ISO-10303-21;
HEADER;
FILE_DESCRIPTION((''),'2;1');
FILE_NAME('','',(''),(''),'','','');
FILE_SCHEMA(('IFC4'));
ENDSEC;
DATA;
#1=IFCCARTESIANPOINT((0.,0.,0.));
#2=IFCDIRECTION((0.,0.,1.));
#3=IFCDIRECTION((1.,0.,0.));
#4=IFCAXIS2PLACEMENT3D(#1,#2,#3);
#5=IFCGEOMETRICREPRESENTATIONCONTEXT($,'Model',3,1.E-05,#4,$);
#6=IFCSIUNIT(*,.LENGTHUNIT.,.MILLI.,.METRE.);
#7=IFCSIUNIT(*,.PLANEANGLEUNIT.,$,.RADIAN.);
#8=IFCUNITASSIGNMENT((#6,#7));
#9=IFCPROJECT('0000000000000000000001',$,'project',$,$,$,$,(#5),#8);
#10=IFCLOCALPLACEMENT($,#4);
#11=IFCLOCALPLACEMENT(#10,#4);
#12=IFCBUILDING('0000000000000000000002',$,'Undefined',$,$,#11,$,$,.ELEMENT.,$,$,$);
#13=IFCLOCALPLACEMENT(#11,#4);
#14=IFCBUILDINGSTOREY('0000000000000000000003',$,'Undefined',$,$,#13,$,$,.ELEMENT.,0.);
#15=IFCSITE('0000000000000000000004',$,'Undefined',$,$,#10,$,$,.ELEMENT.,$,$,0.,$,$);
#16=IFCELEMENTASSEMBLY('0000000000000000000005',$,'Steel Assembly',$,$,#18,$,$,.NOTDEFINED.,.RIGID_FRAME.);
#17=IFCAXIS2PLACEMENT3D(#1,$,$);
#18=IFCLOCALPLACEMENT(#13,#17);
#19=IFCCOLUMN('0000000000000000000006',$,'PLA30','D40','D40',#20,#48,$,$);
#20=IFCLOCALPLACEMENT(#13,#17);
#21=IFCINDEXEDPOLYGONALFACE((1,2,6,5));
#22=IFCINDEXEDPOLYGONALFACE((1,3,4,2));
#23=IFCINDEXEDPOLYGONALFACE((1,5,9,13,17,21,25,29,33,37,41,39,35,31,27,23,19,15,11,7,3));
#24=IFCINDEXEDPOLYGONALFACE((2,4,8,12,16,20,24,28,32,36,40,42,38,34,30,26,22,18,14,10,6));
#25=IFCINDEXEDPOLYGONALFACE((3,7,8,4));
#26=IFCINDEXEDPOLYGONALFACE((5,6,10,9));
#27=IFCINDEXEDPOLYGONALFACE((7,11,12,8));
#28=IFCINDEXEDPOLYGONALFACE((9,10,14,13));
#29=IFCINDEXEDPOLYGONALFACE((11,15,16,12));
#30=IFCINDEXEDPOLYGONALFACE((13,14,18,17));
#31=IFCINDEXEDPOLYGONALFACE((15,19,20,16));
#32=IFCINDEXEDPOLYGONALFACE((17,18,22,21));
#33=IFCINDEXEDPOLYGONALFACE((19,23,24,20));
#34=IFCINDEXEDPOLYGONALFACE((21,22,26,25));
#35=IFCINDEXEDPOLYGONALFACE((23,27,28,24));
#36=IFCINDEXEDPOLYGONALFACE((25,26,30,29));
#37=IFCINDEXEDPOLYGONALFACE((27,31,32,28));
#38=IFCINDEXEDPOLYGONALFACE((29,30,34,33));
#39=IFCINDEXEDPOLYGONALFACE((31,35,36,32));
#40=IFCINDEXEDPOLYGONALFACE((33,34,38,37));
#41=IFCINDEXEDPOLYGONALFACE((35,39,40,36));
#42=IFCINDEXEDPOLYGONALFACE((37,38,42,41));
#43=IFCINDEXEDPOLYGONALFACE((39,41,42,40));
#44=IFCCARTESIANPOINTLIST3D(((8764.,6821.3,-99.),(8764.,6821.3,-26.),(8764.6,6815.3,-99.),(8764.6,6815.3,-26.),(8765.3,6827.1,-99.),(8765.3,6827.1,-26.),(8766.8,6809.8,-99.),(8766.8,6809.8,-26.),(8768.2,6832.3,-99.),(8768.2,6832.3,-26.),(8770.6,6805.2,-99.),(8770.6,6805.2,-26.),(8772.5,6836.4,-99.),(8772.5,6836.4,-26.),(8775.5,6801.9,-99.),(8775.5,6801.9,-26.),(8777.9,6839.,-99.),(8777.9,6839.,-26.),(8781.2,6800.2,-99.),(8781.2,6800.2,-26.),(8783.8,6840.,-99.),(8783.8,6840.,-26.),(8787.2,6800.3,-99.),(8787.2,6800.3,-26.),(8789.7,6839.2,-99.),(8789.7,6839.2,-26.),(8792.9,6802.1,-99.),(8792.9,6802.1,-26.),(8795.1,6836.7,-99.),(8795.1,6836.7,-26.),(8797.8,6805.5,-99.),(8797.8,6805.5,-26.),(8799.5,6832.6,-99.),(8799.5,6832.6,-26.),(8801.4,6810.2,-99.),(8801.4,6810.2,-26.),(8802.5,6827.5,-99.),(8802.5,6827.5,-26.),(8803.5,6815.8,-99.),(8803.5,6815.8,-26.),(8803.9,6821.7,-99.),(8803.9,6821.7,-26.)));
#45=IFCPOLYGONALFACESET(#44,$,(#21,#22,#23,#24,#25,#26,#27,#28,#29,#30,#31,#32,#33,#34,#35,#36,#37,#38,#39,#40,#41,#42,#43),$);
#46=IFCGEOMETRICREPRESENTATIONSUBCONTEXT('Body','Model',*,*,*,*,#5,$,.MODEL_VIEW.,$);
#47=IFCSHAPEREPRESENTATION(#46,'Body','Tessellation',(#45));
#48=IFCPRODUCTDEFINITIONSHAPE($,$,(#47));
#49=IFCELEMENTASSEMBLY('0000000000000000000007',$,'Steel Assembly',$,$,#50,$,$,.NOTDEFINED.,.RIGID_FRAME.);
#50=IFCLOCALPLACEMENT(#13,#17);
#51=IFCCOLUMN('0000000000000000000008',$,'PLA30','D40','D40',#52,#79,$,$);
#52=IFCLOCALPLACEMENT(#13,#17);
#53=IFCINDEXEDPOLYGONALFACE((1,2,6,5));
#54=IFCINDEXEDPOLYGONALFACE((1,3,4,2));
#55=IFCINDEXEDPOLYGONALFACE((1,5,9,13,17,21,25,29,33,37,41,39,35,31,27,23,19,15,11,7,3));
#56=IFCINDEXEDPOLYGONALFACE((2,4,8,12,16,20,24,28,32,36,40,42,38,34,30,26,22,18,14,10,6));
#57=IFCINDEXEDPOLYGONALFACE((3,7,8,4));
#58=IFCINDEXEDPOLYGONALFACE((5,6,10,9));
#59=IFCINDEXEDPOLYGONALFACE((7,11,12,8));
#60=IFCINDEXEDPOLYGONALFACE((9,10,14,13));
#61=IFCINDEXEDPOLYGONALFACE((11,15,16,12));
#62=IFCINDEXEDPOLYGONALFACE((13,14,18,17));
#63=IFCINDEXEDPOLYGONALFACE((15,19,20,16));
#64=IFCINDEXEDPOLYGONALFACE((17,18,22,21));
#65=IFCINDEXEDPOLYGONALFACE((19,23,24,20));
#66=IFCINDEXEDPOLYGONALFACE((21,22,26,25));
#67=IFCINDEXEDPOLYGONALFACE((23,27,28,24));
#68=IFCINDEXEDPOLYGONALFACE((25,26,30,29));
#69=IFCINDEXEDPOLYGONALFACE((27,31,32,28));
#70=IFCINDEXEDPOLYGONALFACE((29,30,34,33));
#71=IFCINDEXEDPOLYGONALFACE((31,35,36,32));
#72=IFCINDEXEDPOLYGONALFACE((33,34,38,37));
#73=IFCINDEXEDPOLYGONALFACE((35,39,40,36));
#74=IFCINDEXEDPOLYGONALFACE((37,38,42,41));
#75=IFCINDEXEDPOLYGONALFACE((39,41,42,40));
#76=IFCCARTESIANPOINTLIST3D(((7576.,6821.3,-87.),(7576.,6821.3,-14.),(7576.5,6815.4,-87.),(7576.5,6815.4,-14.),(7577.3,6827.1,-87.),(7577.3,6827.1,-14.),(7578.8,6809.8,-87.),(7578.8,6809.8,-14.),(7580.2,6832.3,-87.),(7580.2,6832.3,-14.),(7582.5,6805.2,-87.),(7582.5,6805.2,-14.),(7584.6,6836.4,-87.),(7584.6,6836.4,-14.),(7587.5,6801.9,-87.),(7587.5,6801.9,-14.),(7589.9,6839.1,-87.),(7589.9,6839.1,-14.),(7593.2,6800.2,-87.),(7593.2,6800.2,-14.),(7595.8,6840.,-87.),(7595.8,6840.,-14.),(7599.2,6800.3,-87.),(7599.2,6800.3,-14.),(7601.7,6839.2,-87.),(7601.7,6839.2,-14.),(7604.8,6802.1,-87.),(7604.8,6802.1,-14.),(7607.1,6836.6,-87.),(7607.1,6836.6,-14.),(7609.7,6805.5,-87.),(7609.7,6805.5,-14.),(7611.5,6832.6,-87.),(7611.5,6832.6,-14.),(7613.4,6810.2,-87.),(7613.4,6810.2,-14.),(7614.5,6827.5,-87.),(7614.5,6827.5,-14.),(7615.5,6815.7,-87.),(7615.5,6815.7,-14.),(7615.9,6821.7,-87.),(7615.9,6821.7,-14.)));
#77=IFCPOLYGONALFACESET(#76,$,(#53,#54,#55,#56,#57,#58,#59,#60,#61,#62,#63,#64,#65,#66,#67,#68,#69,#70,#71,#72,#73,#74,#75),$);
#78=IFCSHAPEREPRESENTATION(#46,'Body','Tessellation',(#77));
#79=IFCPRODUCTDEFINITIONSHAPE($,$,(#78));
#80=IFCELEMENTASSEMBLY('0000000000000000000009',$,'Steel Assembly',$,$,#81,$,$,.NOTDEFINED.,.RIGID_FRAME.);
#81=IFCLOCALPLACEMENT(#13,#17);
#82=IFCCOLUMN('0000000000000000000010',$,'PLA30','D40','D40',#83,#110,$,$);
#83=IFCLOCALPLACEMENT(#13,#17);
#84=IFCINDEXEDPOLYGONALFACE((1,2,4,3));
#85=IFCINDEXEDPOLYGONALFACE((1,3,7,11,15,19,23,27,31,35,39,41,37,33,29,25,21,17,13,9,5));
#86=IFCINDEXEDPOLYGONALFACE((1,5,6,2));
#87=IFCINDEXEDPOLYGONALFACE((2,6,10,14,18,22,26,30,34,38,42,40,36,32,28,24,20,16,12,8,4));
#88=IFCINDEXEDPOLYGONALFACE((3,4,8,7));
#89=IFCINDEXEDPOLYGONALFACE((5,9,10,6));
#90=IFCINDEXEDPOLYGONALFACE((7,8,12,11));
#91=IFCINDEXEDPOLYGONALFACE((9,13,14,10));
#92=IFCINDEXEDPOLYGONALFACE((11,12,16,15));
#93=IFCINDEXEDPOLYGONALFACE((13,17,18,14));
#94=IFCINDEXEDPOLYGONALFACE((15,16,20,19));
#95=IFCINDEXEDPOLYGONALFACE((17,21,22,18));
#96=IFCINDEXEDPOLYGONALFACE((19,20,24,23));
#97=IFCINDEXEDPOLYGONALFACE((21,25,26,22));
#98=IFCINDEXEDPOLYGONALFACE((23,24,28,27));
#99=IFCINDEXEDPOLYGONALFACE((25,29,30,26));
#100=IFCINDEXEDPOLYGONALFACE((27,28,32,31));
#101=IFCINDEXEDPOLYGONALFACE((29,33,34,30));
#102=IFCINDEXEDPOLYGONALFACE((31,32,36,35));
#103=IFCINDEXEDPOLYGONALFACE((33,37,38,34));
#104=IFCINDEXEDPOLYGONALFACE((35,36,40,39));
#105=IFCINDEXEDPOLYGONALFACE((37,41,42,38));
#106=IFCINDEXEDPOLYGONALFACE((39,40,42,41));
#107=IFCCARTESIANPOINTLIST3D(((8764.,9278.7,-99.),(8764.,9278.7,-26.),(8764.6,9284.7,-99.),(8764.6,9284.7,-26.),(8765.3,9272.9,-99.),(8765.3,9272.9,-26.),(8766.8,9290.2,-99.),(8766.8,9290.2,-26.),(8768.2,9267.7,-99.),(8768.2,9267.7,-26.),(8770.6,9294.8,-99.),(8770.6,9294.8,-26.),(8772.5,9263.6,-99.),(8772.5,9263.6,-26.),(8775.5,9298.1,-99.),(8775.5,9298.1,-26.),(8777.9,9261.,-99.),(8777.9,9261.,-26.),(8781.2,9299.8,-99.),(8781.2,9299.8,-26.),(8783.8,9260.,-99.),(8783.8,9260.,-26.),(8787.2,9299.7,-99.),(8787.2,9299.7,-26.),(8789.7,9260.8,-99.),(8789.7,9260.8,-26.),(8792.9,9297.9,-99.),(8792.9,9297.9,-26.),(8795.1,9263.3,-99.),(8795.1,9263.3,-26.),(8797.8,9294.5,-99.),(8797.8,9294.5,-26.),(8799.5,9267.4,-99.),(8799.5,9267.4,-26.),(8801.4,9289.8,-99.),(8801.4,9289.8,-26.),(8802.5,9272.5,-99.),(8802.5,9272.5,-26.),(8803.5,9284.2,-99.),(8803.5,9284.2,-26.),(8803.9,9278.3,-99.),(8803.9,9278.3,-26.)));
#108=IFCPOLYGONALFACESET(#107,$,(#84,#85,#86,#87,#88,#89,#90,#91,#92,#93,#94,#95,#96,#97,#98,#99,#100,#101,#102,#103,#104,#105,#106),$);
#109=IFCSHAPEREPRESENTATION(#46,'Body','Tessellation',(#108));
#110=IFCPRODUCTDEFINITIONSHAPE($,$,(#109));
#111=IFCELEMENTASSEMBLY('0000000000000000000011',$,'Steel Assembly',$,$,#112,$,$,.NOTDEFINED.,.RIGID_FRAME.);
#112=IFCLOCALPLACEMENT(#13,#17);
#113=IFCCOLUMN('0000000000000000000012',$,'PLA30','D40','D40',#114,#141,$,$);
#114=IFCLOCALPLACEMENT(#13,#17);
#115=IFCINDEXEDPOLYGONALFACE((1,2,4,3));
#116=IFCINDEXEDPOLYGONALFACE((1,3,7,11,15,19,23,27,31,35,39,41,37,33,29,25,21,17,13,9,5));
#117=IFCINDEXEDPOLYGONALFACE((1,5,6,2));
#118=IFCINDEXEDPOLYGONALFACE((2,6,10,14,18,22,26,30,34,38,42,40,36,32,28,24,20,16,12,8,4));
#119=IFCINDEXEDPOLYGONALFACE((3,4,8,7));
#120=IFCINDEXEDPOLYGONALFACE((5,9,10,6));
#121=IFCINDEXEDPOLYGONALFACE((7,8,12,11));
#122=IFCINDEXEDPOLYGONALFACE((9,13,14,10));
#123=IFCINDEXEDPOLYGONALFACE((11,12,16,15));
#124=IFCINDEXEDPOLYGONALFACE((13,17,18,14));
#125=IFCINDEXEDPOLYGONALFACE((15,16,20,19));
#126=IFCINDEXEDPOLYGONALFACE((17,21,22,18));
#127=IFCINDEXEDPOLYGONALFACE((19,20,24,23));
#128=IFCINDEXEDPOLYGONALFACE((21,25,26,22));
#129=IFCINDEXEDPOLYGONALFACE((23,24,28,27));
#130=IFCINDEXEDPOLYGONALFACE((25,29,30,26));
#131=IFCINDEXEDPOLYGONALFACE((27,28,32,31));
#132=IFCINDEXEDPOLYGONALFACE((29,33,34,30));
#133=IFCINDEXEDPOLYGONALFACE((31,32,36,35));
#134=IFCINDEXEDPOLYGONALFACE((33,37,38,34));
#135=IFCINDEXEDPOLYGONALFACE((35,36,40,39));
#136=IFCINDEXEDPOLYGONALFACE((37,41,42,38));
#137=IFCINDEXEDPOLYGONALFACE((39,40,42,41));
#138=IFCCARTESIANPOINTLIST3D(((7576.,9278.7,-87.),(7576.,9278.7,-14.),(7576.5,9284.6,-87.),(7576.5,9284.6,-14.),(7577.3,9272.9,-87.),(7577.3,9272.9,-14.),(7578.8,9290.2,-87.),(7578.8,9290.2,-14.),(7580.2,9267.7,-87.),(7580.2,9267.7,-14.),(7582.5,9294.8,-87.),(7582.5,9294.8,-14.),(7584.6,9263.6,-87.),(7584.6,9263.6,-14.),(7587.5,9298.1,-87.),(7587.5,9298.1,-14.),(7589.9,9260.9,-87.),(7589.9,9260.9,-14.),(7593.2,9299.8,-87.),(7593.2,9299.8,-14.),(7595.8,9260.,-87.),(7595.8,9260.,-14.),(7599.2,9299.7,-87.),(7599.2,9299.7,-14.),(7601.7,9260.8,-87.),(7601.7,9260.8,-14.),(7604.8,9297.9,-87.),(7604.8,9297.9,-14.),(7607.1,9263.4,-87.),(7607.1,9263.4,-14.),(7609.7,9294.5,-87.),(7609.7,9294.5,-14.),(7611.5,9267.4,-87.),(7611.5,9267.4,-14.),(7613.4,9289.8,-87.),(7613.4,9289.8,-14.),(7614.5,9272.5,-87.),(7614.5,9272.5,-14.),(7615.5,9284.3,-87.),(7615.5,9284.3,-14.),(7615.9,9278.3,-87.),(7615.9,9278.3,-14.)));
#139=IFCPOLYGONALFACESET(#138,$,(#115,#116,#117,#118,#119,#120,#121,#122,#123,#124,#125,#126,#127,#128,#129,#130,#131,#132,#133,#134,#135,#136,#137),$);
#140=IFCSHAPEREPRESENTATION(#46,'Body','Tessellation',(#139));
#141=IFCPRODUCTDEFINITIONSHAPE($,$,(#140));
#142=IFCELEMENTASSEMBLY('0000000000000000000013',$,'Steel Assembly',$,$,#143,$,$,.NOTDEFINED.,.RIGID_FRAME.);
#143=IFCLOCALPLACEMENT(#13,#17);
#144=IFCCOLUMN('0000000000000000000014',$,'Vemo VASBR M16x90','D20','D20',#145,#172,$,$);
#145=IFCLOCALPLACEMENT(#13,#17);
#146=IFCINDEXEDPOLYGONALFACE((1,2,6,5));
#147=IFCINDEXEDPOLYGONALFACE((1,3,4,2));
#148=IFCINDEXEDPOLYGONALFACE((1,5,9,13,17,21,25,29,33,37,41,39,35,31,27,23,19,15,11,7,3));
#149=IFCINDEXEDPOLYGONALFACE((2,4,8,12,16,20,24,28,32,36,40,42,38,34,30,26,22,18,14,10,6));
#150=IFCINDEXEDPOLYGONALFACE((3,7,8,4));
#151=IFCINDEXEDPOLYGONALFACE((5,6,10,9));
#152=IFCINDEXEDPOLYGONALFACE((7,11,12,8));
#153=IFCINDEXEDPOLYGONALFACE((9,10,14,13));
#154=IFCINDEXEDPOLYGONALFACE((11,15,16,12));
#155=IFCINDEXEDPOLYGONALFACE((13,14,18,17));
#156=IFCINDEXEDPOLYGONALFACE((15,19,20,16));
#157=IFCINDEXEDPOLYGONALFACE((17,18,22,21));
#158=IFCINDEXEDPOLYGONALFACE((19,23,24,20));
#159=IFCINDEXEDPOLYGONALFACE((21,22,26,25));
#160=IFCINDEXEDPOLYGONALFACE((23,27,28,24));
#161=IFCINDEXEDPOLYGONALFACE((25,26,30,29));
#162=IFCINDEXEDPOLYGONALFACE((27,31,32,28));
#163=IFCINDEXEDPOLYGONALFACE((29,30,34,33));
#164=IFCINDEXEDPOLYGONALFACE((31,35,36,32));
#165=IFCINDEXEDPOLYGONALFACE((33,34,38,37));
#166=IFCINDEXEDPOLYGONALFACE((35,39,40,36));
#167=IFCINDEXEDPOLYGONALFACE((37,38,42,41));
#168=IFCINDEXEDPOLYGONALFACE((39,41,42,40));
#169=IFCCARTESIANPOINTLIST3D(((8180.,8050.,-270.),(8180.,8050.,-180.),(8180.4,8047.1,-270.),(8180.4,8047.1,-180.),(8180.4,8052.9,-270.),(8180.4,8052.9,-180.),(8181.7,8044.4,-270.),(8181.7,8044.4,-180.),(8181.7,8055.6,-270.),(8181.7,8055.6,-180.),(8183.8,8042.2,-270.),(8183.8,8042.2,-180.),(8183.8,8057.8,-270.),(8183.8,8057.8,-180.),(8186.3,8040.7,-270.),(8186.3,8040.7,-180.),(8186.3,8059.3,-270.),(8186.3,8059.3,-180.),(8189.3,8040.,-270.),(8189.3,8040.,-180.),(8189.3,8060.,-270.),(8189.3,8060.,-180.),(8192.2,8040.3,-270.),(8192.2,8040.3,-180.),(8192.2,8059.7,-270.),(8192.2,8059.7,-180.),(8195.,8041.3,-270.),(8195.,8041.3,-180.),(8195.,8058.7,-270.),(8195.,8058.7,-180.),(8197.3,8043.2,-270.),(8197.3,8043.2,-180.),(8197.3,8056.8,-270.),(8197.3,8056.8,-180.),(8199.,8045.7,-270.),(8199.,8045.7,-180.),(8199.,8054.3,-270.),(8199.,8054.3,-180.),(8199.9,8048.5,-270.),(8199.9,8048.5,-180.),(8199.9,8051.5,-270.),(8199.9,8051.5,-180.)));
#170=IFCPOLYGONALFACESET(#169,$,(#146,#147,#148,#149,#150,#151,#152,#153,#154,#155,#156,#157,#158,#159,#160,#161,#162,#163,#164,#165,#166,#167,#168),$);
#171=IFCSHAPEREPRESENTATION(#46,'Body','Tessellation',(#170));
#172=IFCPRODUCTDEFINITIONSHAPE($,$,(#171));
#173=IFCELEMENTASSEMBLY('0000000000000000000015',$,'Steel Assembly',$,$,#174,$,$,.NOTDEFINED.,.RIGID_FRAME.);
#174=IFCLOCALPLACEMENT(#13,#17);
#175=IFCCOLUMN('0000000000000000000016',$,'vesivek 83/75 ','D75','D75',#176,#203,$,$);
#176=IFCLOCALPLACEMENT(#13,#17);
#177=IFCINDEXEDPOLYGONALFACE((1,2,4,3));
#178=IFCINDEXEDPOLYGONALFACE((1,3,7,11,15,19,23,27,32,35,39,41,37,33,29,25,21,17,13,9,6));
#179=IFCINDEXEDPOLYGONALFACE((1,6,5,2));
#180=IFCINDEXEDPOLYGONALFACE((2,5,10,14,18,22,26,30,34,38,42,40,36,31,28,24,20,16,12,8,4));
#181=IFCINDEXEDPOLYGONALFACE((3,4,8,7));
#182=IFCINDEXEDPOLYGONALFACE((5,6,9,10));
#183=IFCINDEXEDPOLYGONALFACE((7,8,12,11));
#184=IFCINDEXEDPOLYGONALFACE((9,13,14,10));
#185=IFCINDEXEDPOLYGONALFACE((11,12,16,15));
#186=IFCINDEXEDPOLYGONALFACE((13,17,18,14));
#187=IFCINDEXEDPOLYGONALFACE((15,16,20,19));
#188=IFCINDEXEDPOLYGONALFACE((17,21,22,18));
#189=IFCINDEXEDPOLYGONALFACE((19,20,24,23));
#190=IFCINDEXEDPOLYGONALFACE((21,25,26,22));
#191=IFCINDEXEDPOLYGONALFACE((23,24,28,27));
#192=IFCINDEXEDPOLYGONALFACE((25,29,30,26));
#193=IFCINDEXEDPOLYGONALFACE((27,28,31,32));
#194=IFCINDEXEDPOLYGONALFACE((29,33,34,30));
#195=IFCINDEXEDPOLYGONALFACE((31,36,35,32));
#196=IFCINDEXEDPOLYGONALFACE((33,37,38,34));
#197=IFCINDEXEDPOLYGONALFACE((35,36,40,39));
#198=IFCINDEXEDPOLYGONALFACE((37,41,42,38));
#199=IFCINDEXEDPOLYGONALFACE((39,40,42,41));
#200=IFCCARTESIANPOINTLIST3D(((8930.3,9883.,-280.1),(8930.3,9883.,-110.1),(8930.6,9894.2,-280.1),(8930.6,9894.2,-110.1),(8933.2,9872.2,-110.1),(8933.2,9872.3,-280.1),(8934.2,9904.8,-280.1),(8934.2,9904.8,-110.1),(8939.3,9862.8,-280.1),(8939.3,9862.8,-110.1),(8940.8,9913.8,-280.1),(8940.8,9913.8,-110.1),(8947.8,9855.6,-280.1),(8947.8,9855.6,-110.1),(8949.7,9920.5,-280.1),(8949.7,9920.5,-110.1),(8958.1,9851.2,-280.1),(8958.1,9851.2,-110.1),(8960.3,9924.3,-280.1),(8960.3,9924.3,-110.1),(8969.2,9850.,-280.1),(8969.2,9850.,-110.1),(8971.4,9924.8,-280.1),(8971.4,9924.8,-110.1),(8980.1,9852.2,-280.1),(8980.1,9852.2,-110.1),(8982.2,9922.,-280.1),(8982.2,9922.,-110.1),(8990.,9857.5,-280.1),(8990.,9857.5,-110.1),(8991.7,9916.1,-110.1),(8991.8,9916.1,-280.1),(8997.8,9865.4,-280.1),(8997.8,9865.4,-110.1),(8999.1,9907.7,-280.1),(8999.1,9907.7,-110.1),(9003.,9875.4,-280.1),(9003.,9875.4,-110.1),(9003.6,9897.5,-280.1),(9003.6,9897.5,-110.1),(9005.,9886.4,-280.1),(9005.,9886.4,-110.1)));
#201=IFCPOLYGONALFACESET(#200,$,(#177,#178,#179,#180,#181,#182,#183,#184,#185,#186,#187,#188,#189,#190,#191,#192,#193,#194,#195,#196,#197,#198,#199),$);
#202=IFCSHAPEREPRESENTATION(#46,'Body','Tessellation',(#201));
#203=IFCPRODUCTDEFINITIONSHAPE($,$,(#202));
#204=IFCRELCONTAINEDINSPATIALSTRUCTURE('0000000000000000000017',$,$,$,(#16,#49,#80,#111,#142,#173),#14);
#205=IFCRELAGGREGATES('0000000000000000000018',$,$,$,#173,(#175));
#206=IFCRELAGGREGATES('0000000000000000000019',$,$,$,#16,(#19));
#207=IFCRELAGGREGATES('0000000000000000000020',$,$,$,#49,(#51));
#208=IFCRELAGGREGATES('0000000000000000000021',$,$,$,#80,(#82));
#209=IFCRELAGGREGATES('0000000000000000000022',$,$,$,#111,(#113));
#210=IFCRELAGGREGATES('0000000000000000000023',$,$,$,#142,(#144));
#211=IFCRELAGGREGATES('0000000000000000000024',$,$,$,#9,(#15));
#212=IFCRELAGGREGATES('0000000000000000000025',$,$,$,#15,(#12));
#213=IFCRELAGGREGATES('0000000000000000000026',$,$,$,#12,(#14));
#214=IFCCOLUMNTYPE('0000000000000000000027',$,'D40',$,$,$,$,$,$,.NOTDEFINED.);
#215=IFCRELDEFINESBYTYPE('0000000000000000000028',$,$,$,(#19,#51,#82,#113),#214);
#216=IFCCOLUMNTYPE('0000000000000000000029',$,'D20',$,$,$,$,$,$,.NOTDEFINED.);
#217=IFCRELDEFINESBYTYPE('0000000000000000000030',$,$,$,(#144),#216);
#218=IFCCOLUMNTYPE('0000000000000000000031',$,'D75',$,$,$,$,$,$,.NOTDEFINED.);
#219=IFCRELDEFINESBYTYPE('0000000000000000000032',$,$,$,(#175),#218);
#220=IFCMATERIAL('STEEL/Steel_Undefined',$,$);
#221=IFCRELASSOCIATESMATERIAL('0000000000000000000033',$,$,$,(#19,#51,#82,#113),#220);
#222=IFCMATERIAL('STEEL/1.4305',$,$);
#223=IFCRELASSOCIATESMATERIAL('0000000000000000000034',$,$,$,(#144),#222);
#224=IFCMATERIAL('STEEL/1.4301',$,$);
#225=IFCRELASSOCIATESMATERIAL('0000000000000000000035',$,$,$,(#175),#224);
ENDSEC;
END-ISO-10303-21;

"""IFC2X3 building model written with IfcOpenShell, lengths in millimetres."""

from ifc_helpers import new_model, si_unit, frame, origin_with_axes, origin_2d_with_axis, place, context, subcontext, project, spatial, circle, extrude, material, type_object, element, aggregate, save


model = new_model("IFC2X3")

# Units and contexts
model_context = context("Model", 3, precision=1e-05, world=origin_with_axes())
body_context = subcontext(model_context, "Body", "Model", "MODEL_VIEW")
ifc_project = project(units=[si_unit("LENGTHUNIT", "METRE", prefix="MILLI"), si_unit("PLANEANGLEUNIT", "RADIAN")], contexts=[model_context])

# Site, building, storey
site_placement = place(None, origin_with_axes())
site = spatial("IfcSite", under=ifc_project, at=site_placement, Name="Undefined", CompositionType="ELEMENT", RefElevation=0.0)
building_placement = place(site_placement, origin_with_axes())
building = spatial("IfcBuilding", under=site, at=building_placement, Name="Undefined", CompositionType="ELEMENT")
storey_placement = place(building_placement, origin_with_axes())
storey = spatial("IfcBuildingStorey", under=building, at=storey_placement, Name="Undefined", CompositionType="ELEMENT", Elevation=0.0)

# Element assemblies, columns
assembly_1_placement = place(storey_placement, origin_with_axes())
assembly_1 = element("IfcElementAssembly", 1, at=assembly_1_placement, inside=storey, Name="Steel Assembly", AssemblyPlace="NOTDEFINED", PredefinedType="RIGID_FRAME")
ifc_material_1 = material(Name="STEEL/Steel_Undefined")
column_type_1 = type_object("IfcColumnType", Name="D40", PredefinedType="NOTDEFINED")
column_1_placement = place(assembly_1_placement, frame((8784.0, 6820.0, -99.0), z_axis=(0.0, 0.0, 1.0), x_axis=(-0.895963, -0.444129, 0.0)))
column_1 = element("IfcColumn", 2, at=column_1_placement, type_object=column_type_1, material=ifc_material_1, Name="PLA30", Description="D40", ObjectType="D40", context=body_context, shape_type="SweptSolid", body=[
    extrude(circle(Radius=20.0, at=origin_2d_with_axis()), frame((0.0, 0.0, 73.0), z_axis=(0.0, 0.0, -1.0), x_axis=(0.0, 1.0, 0.0)), (0.0, 0.0, 1.0), 73.0),
])
assembly_2_placement = place(storey_placement, origin_with_axes())
assembly_2 = element("IfcElementAssembly", 3, at=assembly_2_placement, inside=storey, Name="Steel Assembly", AssemblyPlace="NOTDEFINED", PredefinedType="RIGID_FRAME")
column_2_placement = place(assembly_2_placement, frame((7596.0, 6820.0, -87.0), z_axis=(0.0, 0.0, 1.0), x_axis=(-0.904918, 0.425586, 0.0)))
column_2 = element("IfcColumn", 4, at=column_2_placement, type_object=column_type_1, material=ifc_material_1, Name="PLA30", Description="D40", ObjectType="D40", context=body_context, shape_type="SweptSolid", body=[
    extrude(circle(Radius=20.0, at=origin_2d_with_axis()), frame((0.0, 0.0, 73.0), z_axis=(0.0, 0.0, -1.0), x_axis=(0.0, 1.0, 0.0)), (0.0, 0.0, 1.0), 73.0),
])
assembly_3_placement = place(storey_placement, origin_with_axes())
assembly_3 = element("IfcElementAssembly", 5, at=assembly_3_placement, inside=storey, Name="Steel Assembly", AssemblyPlace="NOTDEFINED", PredefinedType="RIGID_FRAME")
column_3_placement = place(assembly_3_placement, frame((8784.0, 9280.0, -99.0), z_axis=(0.0, 0.0, 1.0), x_axis=(0.896018, -0.444018, 0.0)))
column_3 = element("IfcColumn", 6, at=column_3_placement, type_object=column_type_1, material=ifc_material_1, Name="PLA30", Description="D40", ObjectType="D40", context=body_context, shape_type="SweptSolid", body=[
    extrude(circle(Radius=20.0, at=origin_2d_with_axis()), frame((0.0, 0.0, 73.0), z_axis=(0.0, 0.0, -1.0), x_axis=(0.0, 1.0, 0.0)), (0.0, 0.0, 1.0), 73.0),
])
assembly_4_placement = place(storey_placement, origin_with_axes())
assembly_4 = element("IfcElementAssembly", 7, at=assembly_4_placement, inside=storey, Name="Steel Assembly", AssemblyPlace="NOTDEFINED", PredefinedType="RIGID_FRAME")
column_4_placement = place(assembly_4_placement, frame((7596.0, 9280.0, -87.0), z_axis=(0.0, 0.0, 1.0), x_axis=(0.904969, 0.425477, 0.0)))
column_4 = element("IfcColumn", 8, at=column_4_placement, type_object=column_type_1, material=ifc_material_1, Name="PLA30", Description="D40", ObjectType="D40", context=body_context, shape_type="SweptSolid", body=[
    extrude(circle(Radius=20.0, at=origin_2d_with_axis()), frame((0.0, 0.0, 73.0), z_axis=(0.0, 0.0, -1.0), x_axis=(0.0, 1.0, 0.0)), (0.0, 0.0, 1.0), 73.0),
])
assembly_5_placement = place(storey_placement, origin_with_axes())
assembly_5 = element("IfcElementAssembly", 9, at=assembly_5_placement, inside=storey, Name="Steel Assembly", AssemblyPlace="NOTDEFINED", PredefinedType="RIGID_FRAME")
ifc_material_2 = material(Name="STEEL/1.4305")
column_type_2 = type_object("IfcColumnType", Name="D20", PredefinedType="NOTDEFINED")
column_5_placement = place(assembly_5_placement, frame((8190.0, 8050.0, -270.0), z_axis=(0.0, 0.0, 1.0), x_axis=(0.0, 1.0, 0.0)))
column_5 = element("IfcColumn", 10, at=column_5_placement, type_object=column_type_2, material=ifc_material_2, Name="Vemo VASBR M16x90", Description="D20", ObjectType="D20", context=body_context, shape_type="SweptSolid", body=[
    extrude(circle(Radius=10.0, at=origin_2d_with_axis()), frame((0.0, 0.0, 90.0), z_axis=(0.0, 0.0, -1.0), x_axis=(0.0, 1.0, 0.0)), (0.0, 0.0, 1.0), 90.0),
])
assembly_6_placement = place(storey_placement, origin_with_axes())
assembly_6 = element("IfcElementAssembly", 11, at=assembly_6_placement, inside=storey, Name="Steel Assembly", AssemblyPlace="NOTDEFINED", PredefinedType="RIGID_FRAME")
ifc_material_3 = material(Name="STEEL/1.4301")
column_type_3 = type_object("IfcColumnType", Name="D75", PredefinedType="NOTDEFINED")
column_6_placement = place(assembly_6_placement, frame((8967.5, 9887.5, -280.1), z_axis=(-0.00002, -0.000029, 1.0), x_axis=(0.981183, 0.193079, 0.000026)))
column_6 = element("IfcColumn", 12, at=column_6_placement, type_object=column_type_3, material=ifc_material_3, Name="vesivek 83/75 ", Description="D75", ObjectType="D75", context=body_context, shape_type="SweptSolid", body=[
    extrude(circle(Radius=37.5, at=origin_2d_with_axis()), frame((0.0, 0.0, 170.0), z_axis=(0.0, 0.0, -1.0), x_axis=(0.0, 1.0, 0.0)), (0.0, 0.0, 1.0), 170.0),
])
aggregate(assembly_6, [column_6])

aggregate(assembly_1, [column_1])
aggregate(assembly_2, [column_2])
aggregate(assembly_3, [column_3])
aggregate(assembly_4, [column_4])

aggregate(assembly_5, [column_5])

save(model, "model.ifc")
